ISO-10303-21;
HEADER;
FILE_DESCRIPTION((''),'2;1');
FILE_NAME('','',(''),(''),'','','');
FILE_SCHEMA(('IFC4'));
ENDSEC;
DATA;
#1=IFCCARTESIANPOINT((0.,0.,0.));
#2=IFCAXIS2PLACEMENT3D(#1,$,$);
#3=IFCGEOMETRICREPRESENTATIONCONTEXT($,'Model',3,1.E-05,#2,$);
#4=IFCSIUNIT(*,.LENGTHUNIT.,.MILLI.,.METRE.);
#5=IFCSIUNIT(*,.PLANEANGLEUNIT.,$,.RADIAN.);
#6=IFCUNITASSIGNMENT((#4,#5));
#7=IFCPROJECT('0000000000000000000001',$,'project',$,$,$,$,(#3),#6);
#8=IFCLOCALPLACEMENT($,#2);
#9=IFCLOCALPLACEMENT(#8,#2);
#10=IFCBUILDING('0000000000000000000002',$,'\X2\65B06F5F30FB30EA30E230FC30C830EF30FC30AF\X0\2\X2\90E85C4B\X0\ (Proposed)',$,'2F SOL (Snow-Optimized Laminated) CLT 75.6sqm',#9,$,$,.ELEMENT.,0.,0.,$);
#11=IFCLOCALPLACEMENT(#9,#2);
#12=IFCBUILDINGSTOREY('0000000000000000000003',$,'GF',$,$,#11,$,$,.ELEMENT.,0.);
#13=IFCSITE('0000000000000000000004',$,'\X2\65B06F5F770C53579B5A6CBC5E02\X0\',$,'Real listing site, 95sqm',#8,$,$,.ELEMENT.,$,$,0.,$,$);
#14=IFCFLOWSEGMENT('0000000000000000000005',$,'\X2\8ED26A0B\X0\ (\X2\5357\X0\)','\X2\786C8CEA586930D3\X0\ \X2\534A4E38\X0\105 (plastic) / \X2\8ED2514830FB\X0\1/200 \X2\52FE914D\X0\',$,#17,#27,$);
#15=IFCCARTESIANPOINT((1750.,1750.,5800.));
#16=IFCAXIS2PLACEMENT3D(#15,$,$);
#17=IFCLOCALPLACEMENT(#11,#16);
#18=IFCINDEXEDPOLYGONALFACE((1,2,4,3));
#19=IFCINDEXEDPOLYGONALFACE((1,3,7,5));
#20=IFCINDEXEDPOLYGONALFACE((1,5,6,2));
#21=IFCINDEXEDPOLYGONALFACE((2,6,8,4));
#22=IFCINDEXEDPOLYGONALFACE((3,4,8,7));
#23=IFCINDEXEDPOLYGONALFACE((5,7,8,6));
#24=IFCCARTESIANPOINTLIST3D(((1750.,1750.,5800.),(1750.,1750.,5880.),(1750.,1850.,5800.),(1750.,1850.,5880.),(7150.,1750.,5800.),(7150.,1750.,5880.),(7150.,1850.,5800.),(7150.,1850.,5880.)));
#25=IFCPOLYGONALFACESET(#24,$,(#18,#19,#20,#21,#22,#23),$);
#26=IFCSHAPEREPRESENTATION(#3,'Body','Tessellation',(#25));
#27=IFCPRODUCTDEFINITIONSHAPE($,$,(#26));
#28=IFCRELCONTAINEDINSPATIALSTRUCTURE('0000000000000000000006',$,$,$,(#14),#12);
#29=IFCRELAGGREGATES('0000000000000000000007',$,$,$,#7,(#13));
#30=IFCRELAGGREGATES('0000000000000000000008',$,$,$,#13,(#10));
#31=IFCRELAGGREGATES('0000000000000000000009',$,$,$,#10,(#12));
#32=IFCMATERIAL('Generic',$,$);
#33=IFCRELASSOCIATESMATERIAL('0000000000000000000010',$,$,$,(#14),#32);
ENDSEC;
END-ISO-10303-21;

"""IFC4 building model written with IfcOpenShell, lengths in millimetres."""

from ifc_helpers import new_model, si_unit, frame, frame_2d, origin, place, context, project, spatial, rectangle, extrude, material, element, save


model = new_model("IFC4")

# Units and contexts
model_context = context("Model", 3, precision=1e-05, world=origin())
ifc_project = project(units=[si_unit("LENGTHUNIT", "METRE", prefix="MILLI"), si_unit("PLANEANGLEUNIT", "RADIAN")], contexts=[model_context])

# Site, building, storey
site_placement = place(None, origin())
site = spatial("IfcSite", under=ifc_project, at=site_placement, Name="新潟県南魚沼市", ObjectType="Real listing site, 95sqm", CompositionType="ELEMENT", RefElevation=0.0)
building_placement = place(site_placement, origin())
building = spatial("IfcBuilding", under=site, at=building_placement, Name="新潟・リモートワーク2部屋 (Proposed)", ObjectType="2F SOL (Snow-Optimized Laminated) CLT 75.6sqm", CompositionType="ELEMENT", ElevationOfRefHeight=0.0, ElevationOfTerrain=0.0)
storey_placement = place(building_placement, origin())
storey = spatial("IfcBuildingStorey", under=building, at=storey_placement, Name="GF", CompositionType="ELEMENT", Elevation=0.0)

# Flow segment
ifc_material_1 = material(Name="Generic")
flow_segment_placement = place(storey_placement, frame((1750.0, 1750.0, 5800.0)))
element("IfcFlowSegment", 1, at=flow_segment_placement, inside=storey, material=ifc_material_1, Name="軒樋 (南)", Description="硬質塩ビ 半丸105 (plastic) / 軒先・1/200 勾配", context=model_context, shape_type="SweptSolid", body=[
    extrude(rectangle(XDim=5400.0, YDim=100.0, at=frame_2d((2700.0, 50.0))), frame((1750.0, 1750.0, 5800.0)), (0.0, 0.0, 1.0), 80.0),
])

save(model, "model.ifc")
